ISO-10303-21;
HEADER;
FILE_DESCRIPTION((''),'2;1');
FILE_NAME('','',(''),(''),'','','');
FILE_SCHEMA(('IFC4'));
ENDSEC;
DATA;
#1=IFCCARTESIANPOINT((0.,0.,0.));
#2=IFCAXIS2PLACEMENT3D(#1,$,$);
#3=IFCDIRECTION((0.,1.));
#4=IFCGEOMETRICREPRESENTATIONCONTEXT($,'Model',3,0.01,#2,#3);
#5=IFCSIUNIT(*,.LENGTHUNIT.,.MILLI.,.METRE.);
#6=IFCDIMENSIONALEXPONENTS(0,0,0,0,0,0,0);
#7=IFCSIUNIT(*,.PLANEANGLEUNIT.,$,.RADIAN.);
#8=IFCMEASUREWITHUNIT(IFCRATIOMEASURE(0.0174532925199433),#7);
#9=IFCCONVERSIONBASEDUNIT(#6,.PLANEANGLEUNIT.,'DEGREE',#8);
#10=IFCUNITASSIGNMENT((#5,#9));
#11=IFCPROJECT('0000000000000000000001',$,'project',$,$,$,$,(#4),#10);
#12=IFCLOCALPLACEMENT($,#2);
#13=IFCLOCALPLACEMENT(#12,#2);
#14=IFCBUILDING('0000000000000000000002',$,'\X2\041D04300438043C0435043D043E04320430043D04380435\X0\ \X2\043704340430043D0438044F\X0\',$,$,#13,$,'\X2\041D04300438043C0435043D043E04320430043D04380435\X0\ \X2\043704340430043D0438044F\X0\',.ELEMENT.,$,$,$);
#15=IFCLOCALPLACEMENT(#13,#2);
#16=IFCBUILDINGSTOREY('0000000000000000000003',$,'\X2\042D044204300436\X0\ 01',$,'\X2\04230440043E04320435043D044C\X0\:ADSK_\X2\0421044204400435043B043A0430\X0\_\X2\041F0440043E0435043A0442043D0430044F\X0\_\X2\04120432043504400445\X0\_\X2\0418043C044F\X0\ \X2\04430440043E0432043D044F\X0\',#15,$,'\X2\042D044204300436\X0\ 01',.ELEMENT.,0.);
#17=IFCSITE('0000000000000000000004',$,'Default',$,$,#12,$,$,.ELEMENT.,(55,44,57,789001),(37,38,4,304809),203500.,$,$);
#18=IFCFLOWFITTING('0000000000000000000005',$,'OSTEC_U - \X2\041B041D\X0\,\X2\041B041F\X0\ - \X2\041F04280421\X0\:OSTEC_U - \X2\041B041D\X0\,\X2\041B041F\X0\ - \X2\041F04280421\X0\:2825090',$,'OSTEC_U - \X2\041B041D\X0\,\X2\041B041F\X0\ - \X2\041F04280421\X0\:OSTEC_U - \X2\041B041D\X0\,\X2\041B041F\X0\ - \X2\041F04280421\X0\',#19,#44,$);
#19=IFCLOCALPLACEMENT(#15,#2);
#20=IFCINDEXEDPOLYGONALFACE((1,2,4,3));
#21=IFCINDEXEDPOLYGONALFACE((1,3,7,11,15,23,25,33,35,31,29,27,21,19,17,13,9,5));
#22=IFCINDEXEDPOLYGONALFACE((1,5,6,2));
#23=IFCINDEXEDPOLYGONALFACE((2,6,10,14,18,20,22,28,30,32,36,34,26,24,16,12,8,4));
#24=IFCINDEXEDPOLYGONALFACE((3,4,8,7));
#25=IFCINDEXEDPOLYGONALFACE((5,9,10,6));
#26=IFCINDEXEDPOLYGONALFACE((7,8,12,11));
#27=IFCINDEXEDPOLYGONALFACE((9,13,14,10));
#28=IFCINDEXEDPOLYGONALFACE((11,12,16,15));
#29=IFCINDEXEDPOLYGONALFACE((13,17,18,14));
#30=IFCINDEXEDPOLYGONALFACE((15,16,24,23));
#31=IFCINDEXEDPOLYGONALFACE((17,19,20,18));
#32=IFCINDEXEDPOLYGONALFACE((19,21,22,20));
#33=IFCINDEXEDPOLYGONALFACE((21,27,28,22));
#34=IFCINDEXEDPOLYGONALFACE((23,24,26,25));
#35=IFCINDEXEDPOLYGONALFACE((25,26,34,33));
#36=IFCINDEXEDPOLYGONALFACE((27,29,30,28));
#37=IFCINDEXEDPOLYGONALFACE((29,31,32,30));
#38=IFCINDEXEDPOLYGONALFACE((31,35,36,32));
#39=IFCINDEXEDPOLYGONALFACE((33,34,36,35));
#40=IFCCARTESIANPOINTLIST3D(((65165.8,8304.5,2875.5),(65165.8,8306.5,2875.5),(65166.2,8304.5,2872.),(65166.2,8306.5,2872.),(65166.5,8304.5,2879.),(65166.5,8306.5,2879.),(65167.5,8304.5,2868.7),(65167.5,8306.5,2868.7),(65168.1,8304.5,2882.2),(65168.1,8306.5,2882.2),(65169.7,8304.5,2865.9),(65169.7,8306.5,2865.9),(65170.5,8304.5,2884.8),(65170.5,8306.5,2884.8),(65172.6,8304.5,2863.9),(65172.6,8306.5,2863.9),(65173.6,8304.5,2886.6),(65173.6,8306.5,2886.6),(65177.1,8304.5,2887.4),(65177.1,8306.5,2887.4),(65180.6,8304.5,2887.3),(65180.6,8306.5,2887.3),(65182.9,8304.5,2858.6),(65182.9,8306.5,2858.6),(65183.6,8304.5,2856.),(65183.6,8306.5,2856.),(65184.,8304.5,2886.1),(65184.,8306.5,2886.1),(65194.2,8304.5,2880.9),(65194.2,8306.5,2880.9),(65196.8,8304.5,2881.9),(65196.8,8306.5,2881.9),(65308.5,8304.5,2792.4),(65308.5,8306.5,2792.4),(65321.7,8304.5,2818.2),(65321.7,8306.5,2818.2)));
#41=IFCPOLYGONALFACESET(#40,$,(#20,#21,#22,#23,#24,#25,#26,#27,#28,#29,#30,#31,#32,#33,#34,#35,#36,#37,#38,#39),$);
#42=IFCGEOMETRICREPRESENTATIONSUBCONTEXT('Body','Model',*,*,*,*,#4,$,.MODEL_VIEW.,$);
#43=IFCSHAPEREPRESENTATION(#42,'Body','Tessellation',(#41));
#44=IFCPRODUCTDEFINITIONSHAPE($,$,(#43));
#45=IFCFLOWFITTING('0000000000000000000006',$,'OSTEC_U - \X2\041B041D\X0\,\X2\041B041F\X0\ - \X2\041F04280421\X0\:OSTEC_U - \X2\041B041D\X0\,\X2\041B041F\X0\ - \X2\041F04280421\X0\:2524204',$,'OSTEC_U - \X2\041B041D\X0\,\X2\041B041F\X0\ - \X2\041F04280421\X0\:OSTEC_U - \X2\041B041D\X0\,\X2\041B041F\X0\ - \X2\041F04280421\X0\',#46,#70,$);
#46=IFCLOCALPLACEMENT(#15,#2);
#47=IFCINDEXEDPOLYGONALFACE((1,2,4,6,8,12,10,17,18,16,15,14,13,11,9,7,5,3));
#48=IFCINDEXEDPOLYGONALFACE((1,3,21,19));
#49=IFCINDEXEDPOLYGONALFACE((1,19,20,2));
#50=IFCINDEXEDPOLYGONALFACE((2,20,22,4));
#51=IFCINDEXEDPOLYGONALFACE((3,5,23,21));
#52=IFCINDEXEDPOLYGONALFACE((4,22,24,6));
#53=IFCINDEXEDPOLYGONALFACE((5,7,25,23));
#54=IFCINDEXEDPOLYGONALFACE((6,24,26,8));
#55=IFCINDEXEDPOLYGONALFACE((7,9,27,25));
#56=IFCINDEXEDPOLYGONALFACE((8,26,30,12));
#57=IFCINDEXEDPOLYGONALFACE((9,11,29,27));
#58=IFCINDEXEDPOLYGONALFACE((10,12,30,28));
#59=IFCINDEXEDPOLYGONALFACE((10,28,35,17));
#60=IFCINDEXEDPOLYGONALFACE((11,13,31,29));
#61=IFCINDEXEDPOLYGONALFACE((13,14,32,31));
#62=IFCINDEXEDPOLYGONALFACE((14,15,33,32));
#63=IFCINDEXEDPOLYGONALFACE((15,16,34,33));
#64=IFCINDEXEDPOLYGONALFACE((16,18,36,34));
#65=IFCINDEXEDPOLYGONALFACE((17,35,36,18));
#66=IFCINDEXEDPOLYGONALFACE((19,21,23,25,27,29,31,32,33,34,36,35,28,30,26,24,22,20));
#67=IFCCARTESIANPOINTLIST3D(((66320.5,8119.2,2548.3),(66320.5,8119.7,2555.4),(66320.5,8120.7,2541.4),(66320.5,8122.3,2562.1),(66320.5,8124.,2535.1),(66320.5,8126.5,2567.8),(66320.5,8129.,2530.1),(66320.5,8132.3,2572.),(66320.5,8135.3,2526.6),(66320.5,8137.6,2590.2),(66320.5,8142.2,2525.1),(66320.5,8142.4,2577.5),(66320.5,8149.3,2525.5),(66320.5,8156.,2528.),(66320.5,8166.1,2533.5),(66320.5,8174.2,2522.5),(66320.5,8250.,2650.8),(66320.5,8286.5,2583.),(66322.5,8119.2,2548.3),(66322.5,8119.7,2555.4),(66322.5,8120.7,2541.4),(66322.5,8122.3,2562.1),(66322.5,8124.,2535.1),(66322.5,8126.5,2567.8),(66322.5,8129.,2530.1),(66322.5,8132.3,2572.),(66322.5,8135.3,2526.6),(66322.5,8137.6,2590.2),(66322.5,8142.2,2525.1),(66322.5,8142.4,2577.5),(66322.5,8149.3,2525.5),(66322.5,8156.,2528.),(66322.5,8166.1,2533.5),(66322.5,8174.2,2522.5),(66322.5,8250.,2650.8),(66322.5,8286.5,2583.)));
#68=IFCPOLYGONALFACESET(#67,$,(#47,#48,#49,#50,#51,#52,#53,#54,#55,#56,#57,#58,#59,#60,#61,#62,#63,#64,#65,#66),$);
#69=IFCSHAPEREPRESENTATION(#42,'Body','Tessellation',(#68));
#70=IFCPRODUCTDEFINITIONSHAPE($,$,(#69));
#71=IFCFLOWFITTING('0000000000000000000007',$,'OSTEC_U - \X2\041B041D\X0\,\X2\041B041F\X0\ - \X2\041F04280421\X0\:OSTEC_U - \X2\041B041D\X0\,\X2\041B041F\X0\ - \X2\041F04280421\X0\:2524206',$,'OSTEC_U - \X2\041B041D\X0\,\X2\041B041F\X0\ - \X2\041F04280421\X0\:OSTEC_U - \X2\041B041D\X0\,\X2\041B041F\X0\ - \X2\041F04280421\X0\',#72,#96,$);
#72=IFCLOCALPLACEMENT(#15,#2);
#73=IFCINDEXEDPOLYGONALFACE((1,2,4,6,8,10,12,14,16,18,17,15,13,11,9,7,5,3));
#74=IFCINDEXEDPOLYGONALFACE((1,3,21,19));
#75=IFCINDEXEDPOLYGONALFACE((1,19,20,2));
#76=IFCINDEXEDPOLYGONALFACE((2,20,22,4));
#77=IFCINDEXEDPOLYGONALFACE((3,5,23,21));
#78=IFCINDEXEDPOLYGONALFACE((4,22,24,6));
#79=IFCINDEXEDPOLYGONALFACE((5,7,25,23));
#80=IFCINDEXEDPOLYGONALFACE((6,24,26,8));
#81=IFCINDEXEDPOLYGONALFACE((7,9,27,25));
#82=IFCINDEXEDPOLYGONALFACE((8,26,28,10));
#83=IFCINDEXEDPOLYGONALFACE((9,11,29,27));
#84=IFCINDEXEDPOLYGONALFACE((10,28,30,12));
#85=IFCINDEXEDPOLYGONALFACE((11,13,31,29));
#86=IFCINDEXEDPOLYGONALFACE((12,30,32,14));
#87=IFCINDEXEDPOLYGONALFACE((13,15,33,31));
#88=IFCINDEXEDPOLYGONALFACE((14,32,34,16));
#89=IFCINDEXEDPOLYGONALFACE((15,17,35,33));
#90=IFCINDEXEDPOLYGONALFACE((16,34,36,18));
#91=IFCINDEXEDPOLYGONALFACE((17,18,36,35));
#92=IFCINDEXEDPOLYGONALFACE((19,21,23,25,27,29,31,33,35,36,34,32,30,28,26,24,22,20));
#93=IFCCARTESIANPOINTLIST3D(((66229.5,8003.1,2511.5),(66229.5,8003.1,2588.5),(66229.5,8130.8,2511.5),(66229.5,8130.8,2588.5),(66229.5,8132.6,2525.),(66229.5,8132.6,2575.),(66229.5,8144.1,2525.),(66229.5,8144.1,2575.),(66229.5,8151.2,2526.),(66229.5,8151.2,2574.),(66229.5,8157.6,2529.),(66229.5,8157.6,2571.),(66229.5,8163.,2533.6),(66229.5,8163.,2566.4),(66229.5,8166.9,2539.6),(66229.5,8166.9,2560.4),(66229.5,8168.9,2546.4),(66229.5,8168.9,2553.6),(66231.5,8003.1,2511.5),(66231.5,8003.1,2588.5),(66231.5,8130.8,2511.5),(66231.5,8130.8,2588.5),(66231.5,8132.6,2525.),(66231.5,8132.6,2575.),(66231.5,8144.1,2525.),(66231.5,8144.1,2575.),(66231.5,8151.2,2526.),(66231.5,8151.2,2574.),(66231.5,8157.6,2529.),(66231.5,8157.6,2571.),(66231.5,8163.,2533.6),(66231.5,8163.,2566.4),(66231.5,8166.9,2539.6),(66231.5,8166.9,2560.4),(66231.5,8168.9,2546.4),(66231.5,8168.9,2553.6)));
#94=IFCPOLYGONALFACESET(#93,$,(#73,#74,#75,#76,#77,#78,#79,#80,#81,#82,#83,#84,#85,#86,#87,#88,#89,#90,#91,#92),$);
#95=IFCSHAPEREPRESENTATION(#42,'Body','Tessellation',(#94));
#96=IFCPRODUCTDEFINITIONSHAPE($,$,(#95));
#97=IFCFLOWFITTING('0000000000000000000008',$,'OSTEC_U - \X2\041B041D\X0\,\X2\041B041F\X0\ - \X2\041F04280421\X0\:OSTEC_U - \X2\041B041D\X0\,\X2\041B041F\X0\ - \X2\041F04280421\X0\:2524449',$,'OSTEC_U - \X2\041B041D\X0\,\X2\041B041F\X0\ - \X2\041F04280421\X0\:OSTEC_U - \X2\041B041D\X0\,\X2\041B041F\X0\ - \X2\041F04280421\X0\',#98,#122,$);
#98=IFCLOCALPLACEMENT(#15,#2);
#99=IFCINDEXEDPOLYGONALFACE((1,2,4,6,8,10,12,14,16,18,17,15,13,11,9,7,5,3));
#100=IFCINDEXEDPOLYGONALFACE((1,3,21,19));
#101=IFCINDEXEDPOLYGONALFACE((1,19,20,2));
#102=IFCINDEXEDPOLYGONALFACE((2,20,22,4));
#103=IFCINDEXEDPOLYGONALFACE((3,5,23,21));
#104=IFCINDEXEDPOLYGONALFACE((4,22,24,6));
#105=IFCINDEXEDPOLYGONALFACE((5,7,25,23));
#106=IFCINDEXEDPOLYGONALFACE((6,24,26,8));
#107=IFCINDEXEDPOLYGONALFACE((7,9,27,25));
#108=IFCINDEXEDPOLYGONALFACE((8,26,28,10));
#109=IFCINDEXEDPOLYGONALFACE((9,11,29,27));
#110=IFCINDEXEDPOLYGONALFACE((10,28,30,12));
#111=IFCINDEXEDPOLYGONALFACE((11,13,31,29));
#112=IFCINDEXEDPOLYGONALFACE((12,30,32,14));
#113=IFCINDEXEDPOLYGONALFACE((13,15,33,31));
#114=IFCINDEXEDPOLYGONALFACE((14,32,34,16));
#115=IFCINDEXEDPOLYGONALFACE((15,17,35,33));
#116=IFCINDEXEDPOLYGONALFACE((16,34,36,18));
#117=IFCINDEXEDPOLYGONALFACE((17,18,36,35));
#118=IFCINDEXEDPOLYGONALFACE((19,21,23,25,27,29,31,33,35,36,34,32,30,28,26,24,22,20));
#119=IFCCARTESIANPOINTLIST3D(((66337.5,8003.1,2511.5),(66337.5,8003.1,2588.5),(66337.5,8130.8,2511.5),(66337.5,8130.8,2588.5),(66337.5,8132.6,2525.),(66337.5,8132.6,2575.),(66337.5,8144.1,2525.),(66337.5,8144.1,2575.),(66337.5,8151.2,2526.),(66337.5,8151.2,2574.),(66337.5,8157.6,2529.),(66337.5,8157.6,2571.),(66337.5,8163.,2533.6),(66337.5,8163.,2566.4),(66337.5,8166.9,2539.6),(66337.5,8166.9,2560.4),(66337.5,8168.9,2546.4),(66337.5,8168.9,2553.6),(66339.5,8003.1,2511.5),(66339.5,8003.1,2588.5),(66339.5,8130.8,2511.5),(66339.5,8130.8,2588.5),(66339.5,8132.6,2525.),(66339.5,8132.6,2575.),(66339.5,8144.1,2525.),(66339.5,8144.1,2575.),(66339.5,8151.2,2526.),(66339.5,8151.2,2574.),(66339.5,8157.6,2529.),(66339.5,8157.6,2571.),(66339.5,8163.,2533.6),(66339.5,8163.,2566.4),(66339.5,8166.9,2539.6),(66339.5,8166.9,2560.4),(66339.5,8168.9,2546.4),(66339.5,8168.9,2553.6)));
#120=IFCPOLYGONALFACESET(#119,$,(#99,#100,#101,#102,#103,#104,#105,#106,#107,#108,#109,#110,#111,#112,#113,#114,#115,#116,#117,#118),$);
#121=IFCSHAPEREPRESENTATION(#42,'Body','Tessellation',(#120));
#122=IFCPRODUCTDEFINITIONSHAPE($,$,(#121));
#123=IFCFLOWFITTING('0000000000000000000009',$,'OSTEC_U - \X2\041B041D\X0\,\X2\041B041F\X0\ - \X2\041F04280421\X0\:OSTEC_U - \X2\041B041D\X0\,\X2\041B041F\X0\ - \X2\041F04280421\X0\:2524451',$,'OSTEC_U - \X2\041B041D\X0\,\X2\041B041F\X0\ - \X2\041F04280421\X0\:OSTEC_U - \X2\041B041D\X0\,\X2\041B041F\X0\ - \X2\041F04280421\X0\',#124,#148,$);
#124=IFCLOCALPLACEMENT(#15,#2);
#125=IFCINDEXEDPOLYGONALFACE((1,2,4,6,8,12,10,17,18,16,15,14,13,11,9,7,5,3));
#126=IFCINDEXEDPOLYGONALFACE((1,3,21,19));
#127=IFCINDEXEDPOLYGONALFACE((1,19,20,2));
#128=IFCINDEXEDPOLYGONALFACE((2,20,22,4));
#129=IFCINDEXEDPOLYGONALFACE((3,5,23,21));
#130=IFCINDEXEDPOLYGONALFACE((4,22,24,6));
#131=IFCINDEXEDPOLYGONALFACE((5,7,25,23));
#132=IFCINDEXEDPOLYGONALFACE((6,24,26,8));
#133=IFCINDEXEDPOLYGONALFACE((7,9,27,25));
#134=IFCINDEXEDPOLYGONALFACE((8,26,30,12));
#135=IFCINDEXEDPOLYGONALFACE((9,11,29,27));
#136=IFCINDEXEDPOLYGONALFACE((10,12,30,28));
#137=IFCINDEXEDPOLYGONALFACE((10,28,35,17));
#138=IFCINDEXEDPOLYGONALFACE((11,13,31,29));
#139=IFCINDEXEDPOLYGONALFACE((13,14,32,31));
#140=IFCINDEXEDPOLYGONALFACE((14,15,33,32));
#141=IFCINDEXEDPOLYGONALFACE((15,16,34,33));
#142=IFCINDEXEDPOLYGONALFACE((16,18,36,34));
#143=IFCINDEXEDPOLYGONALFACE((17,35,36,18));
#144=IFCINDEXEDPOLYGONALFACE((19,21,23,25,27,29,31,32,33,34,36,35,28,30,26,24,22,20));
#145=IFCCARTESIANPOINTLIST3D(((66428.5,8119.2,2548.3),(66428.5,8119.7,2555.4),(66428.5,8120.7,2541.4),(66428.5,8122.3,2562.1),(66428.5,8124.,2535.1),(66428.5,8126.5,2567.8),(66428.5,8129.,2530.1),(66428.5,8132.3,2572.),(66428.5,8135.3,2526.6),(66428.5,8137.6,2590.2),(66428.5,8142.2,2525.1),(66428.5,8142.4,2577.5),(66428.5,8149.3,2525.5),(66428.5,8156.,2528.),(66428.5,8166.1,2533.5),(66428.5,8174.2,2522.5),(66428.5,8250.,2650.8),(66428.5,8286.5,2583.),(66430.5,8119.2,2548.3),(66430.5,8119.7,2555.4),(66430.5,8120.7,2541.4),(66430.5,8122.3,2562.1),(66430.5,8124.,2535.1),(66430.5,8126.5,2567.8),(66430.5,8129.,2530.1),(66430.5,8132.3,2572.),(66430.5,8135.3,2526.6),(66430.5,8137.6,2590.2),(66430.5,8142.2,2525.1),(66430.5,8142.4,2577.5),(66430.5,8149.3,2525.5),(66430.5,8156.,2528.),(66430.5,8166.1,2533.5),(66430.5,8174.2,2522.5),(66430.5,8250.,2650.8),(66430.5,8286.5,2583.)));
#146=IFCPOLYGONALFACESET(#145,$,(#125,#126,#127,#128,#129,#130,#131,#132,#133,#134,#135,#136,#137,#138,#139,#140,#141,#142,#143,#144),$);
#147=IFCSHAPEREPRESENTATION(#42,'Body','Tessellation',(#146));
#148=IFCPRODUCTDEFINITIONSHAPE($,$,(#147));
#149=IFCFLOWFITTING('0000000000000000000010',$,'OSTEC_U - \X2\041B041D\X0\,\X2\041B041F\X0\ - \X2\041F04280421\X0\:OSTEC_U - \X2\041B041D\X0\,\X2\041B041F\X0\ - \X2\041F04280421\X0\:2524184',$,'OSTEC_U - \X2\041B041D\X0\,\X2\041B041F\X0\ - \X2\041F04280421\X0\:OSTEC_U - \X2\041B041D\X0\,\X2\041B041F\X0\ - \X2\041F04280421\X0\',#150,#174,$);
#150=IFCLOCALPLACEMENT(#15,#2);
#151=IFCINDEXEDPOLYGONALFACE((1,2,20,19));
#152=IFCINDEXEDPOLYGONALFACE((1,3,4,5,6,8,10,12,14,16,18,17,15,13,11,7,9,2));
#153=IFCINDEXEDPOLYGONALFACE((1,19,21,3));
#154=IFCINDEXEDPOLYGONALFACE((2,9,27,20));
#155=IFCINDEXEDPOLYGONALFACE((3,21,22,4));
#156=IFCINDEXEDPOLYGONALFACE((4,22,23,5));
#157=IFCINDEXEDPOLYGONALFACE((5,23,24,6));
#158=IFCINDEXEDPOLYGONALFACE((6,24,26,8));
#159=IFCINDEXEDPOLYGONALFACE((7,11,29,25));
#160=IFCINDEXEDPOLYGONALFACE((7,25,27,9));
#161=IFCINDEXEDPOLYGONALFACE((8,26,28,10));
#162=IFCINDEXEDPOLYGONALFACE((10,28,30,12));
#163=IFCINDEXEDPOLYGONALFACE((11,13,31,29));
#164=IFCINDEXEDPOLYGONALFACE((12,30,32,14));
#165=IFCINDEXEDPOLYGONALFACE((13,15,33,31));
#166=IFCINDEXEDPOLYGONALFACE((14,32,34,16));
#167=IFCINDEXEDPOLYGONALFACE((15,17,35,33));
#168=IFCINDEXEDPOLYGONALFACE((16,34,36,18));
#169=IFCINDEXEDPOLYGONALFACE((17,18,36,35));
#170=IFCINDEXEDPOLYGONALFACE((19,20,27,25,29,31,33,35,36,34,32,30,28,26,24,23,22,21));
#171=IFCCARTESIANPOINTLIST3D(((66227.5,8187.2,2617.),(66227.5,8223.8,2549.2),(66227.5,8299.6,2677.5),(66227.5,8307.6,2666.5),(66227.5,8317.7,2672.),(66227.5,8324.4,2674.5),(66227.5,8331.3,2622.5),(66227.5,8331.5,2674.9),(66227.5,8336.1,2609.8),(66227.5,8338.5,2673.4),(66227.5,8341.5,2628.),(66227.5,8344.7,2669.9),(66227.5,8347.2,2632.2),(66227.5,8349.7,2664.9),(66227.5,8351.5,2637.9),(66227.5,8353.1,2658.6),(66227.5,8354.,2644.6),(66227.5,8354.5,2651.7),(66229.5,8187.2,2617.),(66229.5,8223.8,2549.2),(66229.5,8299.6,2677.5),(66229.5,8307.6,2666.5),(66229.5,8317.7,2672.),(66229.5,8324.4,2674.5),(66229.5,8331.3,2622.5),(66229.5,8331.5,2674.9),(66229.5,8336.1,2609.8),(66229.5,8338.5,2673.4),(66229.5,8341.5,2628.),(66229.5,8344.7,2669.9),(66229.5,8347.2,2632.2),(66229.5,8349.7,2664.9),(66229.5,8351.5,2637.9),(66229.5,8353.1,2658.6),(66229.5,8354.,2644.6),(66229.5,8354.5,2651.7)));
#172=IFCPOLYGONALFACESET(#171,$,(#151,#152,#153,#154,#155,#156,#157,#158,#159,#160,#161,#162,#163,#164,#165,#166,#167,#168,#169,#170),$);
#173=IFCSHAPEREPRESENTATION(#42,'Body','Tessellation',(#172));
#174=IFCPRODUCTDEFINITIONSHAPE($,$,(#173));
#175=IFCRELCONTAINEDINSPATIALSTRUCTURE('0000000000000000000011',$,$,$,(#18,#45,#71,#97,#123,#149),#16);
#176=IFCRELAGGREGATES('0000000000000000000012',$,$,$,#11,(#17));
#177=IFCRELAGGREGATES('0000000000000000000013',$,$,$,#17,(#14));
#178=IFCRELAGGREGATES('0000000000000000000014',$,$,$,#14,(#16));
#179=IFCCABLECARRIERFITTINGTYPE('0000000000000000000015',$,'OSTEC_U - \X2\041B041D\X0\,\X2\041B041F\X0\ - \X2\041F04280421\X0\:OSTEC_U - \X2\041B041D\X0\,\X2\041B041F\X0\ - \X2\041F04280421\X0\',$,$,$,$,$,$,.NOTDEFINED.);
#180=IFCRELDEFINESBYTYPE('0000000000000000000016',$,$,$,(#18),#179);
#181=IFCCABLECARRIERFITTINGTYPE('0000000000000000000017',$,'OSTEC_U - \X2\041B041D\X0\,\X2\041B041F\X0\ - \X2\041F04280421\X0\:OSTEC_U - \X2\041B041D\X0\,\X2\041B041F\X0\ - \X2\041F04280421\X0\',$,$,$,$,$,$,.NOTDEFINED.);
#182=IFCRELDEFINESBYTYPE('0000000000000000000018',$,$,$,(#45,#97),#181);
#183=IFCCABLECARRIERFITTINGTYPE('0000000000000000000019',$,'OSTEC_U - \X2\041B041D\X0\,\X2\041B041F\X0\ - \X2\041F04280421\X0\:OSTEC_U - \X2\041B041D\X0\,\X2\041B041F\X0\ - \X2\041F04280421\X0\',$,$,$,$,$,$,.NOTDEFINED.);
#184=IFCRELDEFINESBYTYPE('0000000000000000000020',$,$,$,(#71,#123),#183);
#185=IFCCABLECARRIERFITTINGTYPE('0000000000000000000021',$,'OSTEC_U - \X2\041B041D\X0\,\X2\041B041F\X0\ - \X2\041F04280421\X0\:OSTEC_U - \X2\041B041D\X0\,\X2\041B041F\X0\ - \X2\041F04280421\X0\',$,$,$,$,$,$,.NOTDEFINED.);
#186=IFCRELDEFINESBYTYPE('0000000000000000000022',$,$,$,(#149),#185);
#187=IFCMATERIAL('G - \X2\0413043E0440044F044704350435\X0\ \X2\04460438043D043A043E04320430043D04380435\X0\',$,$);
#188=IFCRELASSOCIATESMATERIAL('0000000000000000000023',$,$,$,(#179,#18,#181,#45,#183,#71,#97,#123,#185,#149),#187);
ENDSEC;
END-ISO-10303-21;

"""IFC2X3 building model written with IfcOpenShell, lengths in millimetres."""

from ifc_helpers import new_model, entity, si_unit, converted_unit, direction, frame, frame_2d, origin, place, context, subcontext, project, spatial, polyline, circle_curve, parameter, trimmed, segment, composite_curve, outline, extrude, source, transform, mapped, material, type_object, type_shapes, element, save


model = new_model("IFC2X3")

# Units and contexts
model_context = context("Model", 3, precision=0.01, world=origin(), true_north=direction((0.0, 1.0)))
body_context = subcontext(model_context, "Body", "Model", "MODEL_VIEW")
ifc_project = project(units=[si_unit("LENGTHUNIT", "METRE", prefix="MILLI"), converted_unit("PLANEANGLEUNIT", "DEGREE", entity("IfcRatioMeasure", 0.0174532925199433), si_unit("PLANEANGLEUNIT", "RADIAN"), dimensions=[0, 0, 0, 0, 0, 0, 0])], contexts=[model_context])

# Site, building, storey
site_placement = place(None, origin())
site = spatial("IfcSite", under=ifc_project, at=site_placement, Name="Default", CompositionType="ELEMENT", RefLatitude=(55, 44, 57, 789001), RefLongitude=(37, 38, 4, 304809), RefElevation=203500.0)
building_placement = place(site_placement, origin())
building = spatial("IfcBuilding", under=site, at=building_placement, Name="Наименование здания", LongName="Наименование здания", CompositionType="ELEMENT")
storey_placement = place(building_placement, origin())
storey = spatial("IfcBuildingStorey", under=building, at=storey_placement, Name="Этаж 01", ObjectType="Уровень:ADSK_Стрелка_Проектная_Вверх_Имя уровня", LongName="Этаж 01", CompositionType="ELEMENT", Elevation=0.0)

# Flow fittings
ifc_material = material(Name="G - Горячее цинкование")
shared_shape_1 = source(origin(), body_context, "Body", "SweptSolid", [
    extrude(outline(composite_curve([segment(trimmed(circle_curve(frame_2d((-44.6, 0.0), x_axis=(1.0, 0.0)), 12.5), [parameter(90.0)], [parameter(270.0)], True, "PARAMETER"), True, "CONTINUOUS"), segment(polyline([(-44.6, -12.5), (-33.1, -12.5)]), True, "CONTINUOUS"), segment(polyline([(-33.1, -12.5), (-31.2, -14.5)]), True, "CONTINUOUS"), segment(polyline([(-31.2, -14.5), (108.9, -14.5)]), True, "CONTINUOUS"), segment(polyline([(108.9, -14.5), (108.9, 14.5)]), True, "CONTINUOUS"), segment(polyline([(108.9, 14.5), (-31.2, 14.5)]), True, "CONTINUOUS"), segment(polyline([(-31.2, 14.5), (-33.1, 12.5)]), True, "CONTINUOUS"), segment(polyline([(-33.1, 12.5), (-44.6, 12.5)]), True, "CONTINUOUS")], self_intersect=False)), frame((44.6, 0.0, 0.0)), (0.0, 0.0, 1.0), 2.0),
])
cable_carrier_fitting_type_1 = type_object("IfcCableCarrierFittingType", Name="OSTEC_U - ЛН,ЛП - ПШС:OSTEC_U - ЛН,ЛП - ПШС", PredefinedType="NOTDEFINED", material=ifc_material)
type_shapes(cable_carrier_fitting_type_1, [shared_shape_1])
for number, where, z_axis, x_axis, name in (
    (1, (65178.3, 8306.5, 2875.0), (0.0, -1.0, 0.0), (0.891007, 0.0, -0.45399), "OSTEC_U - ЛН,ЛП - ПШС:OSTEC_U - ЛН,ЛП - ПШС:2825090"),
):
    element("IfcFlowFitting", number, at=place(storey_placement, frame(where, z_axis=z_axis, x_axis=x_axis)), inside=storey, type_object=cable_carrier_fitting_type_1, material=ifc_material, Name=name, ObjectType="OSTEC_U - ЛН,ЛП - ПШС:OSTEC_U - ЛН,ЛП - ПШС", context=body_context, shape_type="MappedRepresentation", body=[
        mapped(shared_shape_1, transform((0.0, 0.0, 0.0), scale=1.0)),
    ])
cable_carrier_fitting_type_2 = type_object("IfcCableCarrierFittingType", Name="OSTEC_U - ЛН,ЛП - ПШС:OSTEC_U - ЛН,ЛП - ПШС", PredefinedType="NOTDEFINED", material=ifc_material)
shared_shape_2 = source(origin(), body_context, "Body", "SweptSolid", [
    extrude(outline(composite_curve([segment(trimmed(circle_curve(frame_2d((-41.5, 0.0), x_axis=(1.0, 0.0)), 25.0), [parameter(90.0)], [parameter(270.0)], True, "PARAMETER"), True, "CONTINUOUS"), segment(polyline([(-41.5, -25.0), (-30.0, -25.0)]), True, "CONTINUOUS"), segment(polyline([(-30.0, -25.0), (-28.1, -38.5)]), True, "CONTINUOUS"), segment(polyline([(-28.1, -38.5), (99.5, -38.5)]), True, "CONTINUOUS"), segment(polyline([(99.5, -38.5), (99.5, 38.5)]), True, "CONTINUOUS"), segment(polyline([(99.5, 38.5), (-28.1, 38.5)]), True, "CONTINUOUS"), segment(polyline([(-28.1, 38.5), (-30.0, 25.0)]), True, "CONTINUOUS"), segment(polyline([(-30.0, 25.0), (-41.5, 25.0)]), True, "CONTINUOUS")], self_intersect=False)), frame((41.5, 0.0, 0.0), z_axis=(0.0, 0.0, -1.0), x_axis=(1.0, 0.0, 0.0)), (0.0, 0.0, -1.0), 2.0),
])
type_shapes(cable_carrier_fitting_type_2, [shared_shape_2])
flow_fitting_1_placement = place(storey_placement, frame((66320.5, 8144.1, 2550.0), z_axis=(1.0, 0.0, 0.0), x_axis=(0.0, 0.880203, 0.474598)))
element("IfcFlowFitting", 2, at=flow_fitting_1_placement, inside=storey, type_object=cable_carrier_fitting_type_2, material=ifc_material, Name="OSTEC_U - ЛН,ЛП - ПШС:OSTEC_U - ЛН,ЛП - ПШС:2524204", ObjectType="OSTEC_U - ЛН,ЛП - ПШС:OSTEC_U - ЛН,ЛП - ПШС", context=body_context, shape_type="MappedRepresentation", body=[
    mapped(shared_shape_2, transform((0.0, 0.0, 0.0), scale=1.0)),
])
cable_carrier_fitting_type_3 = type_object("IfcCableCarrierFittingType", Name="OSTEC_U - ЛН,ЛП - ПШС:OSTEC_U - ЛН,ЛП - ПШС", PredefinedType="NOTDEFINED", material=ifc_material)
type_shapes(cable_carrier_fitting_type_3, [shared_shape_2])
flow_fitting_2_placement = place(storey_placement, frame((66231.5, 8144.1, 2550.0), z_axis=(-1.0, 0.0, 0.0), x_axis=(0.0, -1.0, 0.0)))
element("IfcFlowFitting", 3, at=flow_fitting_2_placement, inside=storey, type_object=cable_carrier_fitting_type_3, material=ifc_material, Name="OSTEC_U - ЛН,ЛП - ПШС:OSTEC_U - ЛН,ЛП - ПШС:2524206", ObjectType="OSTEC_U - ЛН,ЛП - ПШС:OSTEC_U - ЛН,ЛП - ПШС", context=body_context, shape_type="MappedRepresentation", body=[
    mapped(shared_shape_2, transform((0.0, 0.0, 0.0), scale=1.0)),
])
flow_fitting_3_placement = place(storey_placement, frame((66339.5, 8144.1, 2550.0), z_axis=(-1.0, 0.0, 0.0), x_axis=(0.0, -1.0, 0.0)))
element("IfcFlowFitting", 4, at=flow_fitting_3_placement, inside=storey, type_object=cable_carrier_fitting_type_2, material=ifc_material, Name="OSTEC_U - ЛН,ЛП - ПШС:OSTEC_U - ЛН,ЛП - ПШС:2524449", ObjectType="OSTEC_U - ЛН,ЛП - ПШС:OSTEC_U - ЛН,ЛП - ПШС", context=body_context, shape_type="MappedRepresentation", body=[
    mapped(shared_shape_2, transform((0.0, 0.0, 0.0), scale=1.0)),
])
flow_fitting_4_placement = place(storey_placement, frame((66428.5, 8144.1, 2550.0), z_axis=(1.0, 0.0, 0.0), x_axis=(0.0, 0.880203, 0.474598)))
element("IfcFlowFitting", 5, at=flow_fitting_4_placement, inside=storey, type_object=cable_carrier_fitting_type_3, material=ifc_material, Name="OSTEC_U - ЛН,ЛП - ПШС:OSTEC_U - ЛН,ЛП - ПШС:2524451", ObjectType="OSTEC_U - ЛН,ЛП - ПШС:OSTEC_U - ЛН,ЛП - ПШС", context=body_context, shape_type="MappedRepresentation", body=[
    mapped(shared_shape_2, transform((0.0, 0.0, 0.0), scale=1.0)),
])
cable_carrier_fitting_type_4 = type_object("IfcCableCarrierFittingType", Name="OSTEC_U - ЛН,ЛП - ПШС:OSTEC_U - ЛН,ЛП - ПШС", PredefinedType="NOTDEFINED", material=ifc_material)
shared_shape_3 = source(origin(), body_context, "Body", "SweptSolid", [
    extrude(outline(composite_curve([segment(trimmed(circle_curve(frame_2d((-41.5, 0.0), x_axis=(1.0, 0.0)), 25.0), [parameter(90.0)], [parameter(270.0)], True, "PARAMETER"), True, "CONTINUOUS"), segment(polyline([(-41.5, -25.0), (-30.0, -25.0)]), True, "CONTINUOUS"), segment(polyline([(-30.0, -25.0), (-28.1, -38.5)]), True, "CONTINUOUS"), segment(polyline([(-28.1, -38.5), (99.5, -38.5)]), True, "CONTINUOUS"), segment(polyline([(99.5, -38.5), (99.5, 38.5)]), True, "CONTINUOUS"), segment(polyline([(99.5, 38.5), (-28.1, 38.5)]), True, "CONTINUOUS"), segment(polyline([(-28.1, 38.5), (-30.0, 25.0)]), True, "CONTINUOUS"), segment(polyline([(-30.0, 25.0), (-41.5, 25.0)]), True, "CONTINUOUS")], self_intersect=False)), frame((41.5, 0.0, 0.0)), (0.0, 0.0, 1.0), 2.0),
])
type_shapes(cable_carrier_fitting_type_4, [shared_shape_3])
for number, where, z_axis, x_axis, name in (
    (6, (66229.5, 8329.6, 2650.0), (-1.0, 0.0, 0.0), (0.0, -0.880203, -0.474598), "OSTEC_U - ЛН,ЛП - ПШС:OSTEC_U - ЛН,ЛП - ПШС:2524184"),
):
    element("IfcFlowFitting", number, at=place(storey_placement, frame(where, z_axis=z_axis, x_axis=x_axis)), inside=storey, type_object=cable_carrier_fitting_type_4, material=ifc_material, Name=name, ObjectType="OSTEC_U - ЛН,ЛП - ПШС:OSTEC_U - ЛН,ЛП - ПШС", context=body_context, shape_type="MappedRepresentation", body=[
        mapped(shared_shape_3, transform((0.0, 0.0, 0.0), scale=1.0)),
    ])

save(model, "model.ifc")
